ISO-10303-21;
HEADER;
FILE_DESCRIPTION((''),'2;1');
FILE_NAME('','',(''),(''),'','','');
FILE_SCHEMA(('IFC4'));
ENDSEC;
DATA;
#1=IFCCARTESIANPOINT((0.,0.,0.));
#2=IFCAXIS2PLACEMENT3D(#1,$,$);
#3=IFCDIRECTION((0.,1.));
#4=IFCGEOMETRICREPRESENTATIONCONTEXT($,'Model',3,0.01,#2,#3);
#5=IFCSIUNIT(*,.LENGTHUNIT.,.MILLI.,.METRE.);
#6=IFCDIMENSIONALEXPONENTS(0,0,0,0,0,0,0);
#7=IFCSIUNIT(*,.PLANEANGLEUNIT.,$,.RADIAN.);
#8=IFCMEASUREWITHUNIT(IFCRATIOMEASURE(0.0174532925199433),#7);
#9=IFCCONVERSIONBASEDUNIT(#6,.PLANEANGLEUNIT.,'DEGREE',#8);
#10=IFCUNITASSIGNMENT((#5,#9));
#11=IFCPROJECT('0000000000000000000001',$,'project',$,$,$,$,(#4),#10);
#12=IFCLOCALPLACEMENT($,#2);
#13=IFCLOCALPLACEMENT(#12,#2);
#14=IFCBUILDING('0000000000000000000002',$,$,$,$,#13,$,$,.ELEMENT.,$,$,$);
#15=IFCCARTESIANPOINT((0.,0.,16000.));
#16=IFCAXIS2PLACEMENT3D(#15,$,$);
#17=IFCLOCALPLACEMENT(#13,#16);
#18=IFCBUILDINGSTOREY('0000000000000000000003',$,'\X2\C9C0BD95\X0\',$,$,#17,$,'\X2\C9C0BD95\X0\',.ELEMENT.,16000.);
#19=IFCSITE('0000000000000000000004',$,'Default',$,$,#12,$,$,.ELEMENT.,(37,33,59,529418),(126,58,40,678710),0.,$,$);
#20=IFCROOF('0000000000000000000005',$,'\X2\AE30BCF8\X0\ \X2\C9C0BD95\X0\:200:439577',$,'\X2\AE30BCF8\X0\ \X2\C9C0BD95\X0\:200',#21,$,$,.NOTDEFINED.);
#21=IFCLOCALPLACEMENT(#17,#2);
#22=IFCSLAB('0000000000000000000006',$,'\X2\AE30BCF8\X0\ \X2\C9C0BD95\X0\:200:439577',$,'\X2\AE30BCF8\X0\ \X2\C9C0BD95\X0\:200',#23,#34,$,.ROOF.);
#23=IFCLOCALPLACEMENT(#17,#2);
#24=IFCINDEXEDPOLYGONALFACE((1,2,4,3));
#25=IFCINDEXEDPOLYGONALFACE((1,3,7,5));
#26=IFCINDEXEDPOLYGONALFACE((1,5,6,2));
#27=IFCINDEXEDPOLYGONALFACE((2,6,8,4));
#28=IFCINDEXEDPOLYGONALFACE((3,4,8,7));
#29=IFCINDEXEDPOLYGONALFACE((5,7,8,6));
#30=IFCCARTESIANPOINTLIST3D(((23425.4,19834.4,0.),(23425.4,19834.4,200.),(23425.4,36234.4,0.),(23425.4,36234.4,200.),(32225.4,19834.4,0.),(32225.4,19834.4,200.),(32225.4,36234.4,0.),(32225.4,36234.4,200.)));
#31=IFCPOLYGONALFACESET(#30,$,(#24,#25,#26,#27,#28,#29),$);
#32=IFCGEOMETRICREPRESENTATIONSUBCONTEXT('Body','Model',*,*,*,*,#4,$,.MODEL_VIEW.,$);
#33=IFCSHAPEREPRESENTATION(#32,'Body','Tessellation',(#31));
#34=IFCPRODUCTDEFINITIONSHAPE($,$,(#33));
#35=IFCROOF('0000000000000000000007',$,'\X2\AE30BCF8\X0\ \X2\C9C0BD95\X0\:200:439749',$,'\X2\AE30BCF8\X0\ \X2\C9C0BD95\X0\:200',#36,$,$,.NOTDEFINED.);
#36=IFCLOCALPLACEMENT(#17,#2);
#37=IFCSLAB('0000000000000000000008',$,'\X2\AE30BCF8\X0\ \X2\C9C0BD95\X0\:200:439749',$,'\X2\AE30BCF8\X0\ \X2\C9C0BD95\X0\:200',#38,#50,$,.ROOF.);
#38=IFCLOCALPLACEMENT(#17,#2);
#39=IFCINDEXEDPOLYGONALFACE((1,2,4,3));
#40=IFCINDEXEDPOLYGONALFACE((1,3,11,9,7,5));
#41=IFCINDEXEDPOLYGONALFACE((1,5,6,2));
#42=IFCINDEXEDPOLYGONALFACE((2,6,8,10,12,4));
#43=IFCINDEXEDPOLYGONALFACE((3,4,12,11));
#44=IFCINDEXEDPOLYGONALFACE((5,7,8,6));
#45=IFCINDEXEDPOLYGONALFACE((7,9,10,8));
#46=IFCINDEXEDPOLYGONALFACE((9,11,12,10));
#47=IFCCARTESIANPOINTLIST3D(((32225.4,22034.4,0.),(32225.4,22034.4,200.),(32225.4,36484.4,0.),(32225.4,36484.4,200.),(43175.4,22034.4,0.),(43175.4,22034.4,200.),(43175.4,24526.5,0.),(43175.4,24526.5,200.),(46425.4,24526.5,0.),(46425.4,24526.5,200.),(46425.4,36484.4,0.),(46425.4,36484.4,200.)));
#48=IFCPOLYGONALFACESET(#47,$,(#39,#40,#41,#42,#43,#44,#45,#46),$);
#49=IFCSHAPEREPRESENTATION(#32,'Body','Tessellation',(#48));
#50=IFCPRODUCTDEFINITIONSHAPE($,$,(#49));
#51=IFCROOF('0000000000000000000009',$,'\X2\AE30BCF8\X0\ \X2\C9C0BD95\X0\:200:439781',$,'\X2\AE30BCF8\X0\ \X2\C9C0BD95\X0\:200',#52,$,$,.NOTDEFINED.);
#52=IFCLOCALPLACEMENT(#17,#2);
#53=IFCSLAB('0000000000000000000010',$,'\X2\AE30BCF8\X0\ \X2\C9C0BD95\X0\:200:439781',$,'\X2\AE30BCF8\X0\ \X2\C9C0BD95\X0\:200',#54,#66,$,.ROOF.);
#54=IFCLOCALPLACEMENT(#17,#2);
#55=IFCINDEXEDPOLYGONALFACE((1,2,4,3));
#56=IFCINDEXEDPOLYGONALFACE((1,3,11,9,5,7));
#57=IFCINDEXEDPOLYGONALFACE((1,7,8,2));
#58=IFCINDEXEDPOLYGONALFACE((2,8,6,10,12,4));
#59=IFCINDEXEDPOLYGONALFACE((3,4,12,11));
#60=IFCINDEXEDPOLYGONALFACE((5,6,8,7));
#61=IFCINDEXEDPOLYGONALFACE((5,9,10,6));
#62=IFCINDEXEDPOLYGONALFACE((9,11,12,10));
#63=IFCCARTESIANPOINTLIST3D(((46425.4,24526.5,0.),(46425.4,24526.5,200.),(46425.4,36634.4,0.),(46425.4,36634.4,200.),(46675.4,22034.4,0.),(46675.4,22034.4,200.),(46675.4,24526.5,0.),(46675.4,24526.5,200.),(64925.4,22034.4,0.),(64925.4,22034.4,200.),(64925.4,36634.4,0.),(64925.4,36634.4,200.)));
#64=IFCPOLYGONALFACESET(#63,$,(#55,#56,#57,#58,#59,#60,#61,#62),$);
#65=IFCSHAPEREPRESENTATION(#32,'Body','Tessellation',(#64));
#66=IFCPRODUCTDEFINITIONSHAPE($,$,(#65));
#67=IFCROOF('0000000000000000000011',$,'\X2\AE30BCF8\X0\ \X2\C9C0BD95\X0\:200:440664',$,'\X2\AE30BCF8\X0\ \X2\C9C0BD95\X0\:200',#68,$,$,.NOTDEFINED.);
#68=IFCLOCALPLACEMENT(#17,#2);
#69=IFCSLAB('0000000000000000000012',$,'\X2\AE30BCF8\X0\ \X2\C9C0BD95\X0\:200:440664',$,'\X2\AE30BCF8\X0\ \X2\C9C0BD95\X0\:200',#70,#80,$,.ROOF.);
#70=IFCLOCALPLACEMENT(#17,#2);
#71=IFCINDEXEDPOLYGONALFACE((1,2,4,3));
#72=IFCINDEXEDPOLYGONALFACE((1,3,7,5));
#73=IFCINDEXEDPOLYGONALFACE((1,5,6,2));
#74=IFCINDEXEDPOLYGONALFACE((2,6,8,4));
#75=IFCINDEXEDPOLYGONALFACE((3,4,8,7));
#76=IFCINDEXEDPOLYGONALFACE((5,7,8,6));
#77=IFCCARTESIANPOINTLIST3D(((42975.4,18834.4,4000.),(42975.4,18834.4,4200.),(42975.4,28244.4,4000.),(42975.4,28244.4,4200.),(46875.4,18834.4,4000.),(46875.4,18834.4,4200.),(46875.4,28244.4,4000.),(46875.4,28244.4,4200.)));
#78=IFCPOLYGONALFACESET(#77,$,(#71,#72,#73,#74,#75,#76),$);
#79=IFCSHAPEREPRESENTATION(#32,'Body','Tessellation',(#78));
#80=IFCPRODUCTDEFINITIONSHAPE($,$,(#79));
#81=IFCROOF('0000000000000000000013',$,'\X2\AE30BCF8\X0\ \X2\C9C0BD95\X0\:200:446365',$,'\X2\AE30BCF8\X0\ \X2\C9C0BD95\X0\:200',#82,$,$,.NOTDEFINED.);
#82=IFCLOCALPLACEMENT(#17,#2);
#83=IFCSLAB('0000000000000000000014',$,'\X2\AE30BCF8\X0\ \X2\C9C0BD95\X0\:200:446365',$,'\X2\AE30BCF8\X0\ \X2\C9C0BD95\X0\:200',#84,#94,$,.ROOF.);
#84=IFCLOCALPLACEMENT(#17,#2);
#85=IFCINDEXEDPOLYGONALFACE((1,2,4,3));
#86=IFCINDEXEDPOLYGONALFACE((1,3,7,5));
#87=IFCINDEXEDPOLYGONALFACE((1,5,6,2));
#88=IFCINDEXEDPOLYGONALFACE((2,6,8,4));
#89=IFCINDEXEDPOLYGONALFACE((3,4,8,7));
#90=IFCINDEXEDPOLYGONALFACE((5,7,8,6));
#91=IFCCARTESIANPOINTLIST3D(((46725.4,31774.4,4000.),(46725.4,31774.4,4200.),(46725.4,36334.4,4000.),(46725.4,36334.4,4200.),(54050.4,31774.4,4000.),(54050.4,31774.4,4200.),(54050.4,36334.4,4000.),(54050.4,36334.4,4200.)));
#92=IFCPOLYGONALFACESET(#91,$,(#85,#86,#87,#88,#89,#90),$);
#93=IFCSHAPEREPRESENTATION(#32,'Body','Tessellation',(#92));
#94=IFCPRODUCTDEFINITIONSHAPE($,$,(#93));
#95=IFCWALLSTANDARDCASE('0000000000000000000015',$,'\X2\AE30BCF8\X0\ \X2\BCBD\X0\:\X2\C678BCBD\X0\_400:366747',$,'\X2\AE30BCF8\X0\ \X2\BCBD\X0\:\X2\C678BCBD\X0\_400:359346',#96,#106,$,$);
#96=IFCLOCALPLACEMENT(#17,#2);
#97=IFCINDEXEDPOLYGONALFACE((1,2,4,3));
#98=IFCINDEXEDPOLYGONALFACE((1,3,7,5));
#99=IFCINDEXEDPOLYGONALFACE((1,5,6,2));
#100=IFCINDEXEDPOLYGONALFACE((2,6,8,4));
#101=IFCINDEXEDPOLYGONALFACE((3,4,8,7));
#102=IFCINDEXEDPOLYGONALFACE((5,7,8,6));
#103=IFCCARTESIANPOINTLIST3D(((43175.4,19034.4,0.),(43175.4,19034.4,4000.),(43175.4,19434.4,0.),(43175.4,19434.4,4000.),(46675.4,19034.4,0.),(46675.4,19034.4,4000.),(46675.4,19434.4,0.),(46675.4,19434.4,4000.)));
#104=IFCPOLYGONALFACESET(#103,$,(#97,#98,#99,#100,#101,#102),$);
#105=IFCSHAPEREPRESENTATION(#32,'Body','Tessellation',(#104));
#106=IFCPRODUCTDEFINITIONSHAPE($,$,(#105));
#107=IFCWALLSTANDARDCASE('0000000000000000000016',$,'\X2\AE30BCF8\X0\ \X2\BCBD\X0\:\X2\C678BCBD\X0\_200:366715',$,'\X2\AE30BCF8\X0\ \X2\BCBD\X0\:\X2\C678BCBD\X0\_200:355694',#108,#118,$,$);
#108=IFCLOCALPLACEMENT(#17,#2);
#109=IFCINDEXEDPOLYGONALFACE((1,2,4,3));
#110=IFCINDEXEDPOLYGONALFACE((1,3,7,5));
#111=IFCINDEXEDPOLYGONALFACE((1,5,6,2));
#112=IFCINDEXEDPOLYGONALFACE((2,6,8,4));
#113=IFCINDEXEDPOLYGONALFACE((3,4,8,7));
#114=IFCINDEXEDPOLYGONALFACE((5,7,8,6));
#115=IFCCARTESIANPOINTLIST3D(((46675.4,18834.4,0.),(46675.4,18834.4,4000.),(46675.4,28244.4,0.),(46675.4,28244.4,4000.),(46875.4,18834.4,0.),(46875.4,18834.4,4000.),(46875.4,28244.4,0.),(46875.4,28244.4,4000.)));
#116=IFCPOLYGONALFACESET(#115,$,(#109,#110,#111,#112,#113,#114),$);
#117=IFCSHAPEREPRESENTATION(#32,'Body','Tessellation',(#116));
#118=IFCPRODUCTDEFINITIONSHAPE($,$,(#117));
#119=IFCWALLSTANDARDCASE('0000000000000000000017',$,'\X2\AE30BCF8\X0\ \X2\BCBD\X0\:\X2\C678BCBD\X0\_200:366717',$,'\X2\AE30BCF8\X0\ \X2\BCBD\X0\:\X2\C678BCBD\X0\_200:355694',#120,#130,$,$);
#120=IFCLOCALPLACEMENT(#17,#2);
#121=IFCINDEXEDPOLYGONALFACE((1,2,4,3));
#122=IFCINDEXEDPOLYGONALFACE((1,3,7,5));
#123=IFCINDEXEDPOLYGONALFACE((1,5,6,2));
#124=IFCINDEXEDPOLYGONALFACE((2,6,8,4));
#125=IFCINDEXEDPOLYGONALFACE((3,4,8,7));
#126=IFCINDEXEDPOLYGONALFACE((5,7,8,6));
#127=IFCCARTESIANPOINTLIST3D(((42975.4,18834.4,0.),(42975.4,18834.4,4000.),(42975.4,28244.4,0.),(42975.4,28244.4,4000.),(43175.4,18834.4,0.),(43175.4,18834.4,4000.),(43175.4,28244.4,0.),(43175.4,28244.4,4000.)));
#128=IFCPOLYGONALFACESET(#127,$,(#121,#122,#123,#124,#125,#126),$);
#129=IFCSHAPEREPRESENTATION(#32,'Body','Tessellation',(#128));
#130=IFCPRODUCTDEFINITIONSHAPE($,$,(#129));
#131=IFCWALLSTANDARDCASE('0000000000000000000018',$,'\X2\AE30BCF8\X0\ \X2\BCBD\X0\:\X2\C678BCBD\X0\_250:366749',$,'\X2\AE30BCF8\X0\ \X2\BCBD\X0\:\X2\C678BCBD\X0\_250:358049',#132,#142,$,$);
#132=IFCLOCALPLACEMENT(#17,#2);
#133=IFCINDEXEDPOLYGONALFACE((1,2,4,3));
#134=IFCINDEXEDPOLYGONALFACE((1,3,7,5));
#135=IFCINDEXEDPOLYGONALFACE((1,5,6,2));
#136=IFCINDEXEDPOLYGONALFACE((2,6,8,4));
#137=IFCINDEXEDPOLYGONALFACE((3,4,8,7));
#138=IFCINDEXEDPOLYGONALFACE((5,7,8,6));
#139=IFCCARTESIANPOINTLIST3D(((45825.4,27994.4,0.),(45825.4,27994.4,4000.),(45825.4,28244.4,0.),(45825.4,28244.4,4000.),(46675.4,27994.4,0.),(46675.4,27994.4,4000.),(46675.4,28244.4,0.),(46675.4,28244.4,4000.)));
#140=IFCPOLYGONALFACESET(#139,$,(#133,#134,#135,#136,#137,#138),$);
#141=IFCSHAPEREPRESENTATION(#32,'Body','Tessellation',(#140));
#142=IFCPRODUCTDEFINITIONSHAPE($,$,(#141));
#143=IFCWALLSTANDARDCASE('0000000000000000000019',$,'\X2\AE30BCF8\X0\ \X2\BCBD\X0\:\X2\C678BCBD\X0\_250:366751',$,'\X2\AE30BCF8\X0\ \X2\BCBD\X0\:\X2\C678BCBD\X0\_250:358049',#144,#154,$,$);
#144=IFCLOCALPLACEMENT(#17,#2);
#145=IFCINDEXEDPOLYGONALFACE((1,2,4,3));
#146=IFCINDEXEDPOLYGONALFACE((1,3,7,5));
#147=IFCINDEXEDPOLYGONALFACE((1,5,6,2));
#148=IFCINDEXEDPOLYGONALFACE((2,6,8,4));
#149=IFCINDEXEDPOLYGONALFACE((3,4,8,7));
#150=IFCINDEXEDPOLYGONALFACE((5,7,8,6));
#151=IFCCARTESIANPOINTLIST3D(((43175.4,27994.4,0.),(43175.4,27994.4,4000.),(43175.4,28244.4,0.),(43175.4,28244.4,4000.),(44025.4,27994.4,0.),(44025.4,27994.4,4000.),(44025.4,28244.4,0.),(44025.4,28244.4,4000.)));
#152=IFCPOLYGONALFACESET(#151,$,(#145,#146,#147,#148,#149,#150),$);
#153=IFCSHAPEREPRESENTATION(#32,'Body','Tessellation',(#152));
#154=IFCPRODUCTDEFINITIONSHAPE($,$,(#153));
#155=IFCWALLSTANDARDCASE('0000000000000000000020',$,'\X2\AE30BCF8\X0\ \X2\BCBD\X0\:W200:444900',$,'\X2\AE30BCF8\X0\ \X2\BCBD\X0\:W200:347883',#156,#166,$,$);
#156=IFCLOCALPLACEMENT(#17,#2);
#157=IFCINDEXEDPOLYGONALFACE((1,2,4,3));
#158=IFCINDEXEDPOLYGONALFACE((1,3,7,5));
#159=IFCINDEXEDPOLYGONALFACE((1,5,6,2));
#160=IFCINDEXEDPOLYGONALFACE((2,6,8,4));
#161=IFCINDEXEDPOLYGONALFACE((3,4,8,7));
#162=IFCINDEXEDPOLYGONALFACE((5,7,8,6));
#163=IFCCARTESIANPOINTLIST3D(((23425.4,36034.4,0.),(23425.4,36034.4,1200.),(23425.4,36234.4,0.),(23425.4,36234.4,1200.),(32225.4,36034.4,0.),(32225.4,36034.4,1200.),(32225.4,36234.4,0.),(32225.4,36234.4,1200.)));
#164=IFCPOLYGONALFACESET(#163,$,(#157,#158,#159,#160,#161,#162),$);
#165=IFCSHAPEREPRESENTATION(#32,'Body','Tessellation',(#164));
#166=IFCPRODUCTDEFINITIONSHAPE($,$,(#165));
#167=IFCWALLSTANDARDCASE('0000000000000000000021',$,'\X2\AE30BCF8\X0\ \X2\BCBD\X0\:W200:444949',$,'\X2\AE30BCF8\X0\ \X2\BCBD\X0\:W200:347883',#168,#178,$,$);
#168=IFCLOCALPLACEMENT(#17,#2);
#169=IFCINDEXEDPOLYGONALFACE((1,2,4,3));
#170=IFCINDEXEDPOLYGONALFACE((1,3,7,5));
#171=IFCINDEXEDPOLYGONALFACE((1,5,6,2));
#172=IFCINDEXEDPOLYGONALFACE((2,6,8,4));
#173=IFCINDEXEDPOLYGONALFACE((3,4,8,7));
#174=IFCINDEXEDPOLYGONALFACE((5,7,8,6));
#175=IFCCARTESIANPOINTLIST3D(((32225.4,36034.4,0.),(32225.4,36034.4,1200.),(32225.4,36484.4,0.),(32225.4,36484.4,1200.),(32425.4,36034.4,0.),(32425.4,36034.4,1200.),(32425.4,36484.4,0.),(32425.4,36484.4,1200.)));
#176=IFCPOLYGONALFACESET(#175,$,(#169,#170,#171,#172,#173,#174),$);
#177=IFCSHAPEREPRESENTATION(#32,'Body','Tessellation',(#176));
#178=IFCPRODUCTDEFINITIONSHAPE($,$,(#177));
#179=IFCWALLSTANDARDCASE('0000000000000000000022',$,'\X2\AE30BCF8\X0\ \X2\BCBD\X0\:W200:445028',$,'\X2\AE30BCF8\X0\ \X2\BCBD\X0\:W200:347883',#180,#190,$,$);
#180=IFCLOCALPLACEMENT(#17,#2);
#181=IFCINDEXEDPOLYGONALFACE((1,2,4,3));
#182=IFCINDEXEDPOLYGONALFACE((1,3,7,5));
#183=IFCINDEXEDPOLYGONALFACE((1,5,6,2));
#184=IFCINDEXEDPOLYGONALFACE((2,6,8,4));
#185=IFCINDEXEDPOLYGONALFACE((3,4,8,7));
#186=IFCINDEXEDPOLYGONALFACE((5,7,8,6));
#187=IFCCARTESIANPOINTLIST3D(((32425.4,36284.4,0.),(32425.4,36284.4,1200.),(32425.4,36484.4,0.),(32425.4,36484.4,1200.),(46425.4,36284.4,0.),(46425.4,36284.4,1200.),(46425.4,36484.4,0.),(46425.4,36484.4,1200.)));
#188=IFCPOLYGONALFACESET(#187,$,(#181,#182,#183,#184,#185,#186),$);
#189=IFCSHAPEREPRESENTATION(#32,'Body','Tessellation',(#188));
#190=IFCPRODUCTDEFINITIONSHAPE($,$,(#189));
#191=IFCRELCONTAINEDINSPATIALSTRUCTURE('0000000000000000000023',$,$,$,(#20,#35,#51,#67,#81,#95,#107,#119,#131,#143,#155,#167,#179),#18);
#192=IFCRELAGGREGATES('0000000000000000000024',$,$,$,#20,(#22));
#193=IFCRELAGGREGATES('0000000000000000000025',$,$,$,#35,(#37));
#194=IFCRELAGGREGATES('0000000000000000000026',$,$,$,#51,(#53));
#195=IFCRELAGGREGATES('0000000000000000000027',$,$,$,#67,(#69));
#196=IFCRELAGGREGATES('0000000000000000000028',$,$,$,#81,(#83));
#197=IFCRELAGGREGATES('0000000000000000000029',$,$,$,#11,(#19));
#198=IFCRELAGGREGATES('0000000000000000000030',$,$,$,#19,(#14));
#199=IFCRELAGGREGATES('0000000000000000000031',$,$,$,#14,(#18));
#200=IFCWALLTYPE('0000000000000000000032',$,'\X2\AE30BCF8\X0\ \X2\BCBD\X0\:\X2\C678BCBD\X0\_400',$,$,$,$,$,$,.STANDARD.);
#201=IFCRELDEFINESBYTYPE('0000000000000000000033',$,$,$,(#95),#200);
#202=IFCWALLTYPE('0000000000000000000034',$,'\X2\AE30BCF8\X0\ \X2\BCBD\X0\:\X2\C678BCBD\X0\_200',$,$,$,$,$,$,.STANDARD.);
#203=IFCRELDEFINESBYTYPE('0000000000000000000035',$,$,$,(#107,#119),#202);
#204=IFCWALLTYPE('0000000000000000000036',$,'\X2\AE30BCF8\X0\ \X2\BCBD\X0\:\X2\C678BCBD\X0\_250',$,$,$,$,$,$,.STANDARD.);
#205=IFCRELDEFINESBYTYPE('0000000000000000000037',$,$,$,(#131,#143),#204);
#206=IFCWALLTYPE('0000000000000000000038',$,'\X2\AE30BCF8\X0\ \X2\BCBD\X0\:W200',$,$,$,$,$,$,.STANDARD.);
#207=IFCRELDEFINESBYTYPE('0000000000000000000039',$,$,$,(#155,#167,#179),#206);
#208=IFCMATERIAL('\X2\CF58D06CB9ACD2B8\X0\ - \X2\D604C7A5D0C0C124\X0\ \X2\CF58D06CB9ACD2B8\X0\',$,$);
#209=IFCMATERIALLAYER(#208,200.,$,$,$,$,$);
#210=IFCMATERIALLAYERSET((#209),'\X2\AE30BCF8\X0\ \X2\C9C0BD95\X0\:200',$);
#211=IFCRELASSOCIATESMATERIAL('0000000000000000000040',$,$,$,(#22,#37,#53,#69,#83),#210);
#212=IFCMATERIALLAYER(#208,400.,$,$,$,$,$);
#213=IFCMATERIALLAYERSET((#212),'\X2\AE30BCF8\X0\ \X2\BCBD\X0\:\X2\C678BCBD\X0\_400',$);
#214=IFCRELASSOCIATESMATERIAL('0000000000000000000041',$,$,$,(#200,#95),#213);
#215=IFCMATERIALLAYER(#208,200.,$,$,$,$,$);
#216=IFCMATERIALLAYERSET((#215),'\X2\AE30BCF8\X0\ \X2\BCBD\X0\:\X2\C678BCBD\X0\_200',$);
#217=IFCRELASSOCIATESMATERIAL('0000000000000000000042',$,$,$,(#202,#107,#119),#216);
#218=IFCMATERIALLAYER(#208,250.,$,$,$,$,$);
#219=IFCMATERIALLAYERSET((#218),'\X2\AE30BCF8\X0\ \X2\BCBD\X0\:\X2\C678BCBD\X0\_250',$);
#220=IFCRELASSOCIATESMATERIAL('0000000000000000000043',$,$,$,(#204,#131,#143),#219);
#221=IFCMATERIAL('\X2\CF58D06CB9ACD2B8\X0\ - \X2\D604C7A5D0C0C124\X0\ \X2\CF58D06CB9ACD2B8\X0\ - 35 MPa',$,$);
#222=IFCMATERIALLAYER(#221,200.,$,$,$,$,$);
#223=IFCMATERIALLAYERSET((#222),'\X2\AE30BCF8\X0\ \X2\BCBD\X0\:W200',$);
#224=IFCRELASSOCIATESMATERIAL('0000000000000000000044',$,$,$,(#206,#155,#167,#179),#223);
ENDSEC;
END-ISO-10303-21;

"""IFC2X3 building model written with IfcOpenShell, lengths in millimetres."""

from ifc_helpers import new_model, entity, si_unit, converted_unit, direction, frame, frame_2d, origin, place, context, subcontext, project, spatial, polyline, rectangle, outline, extrude, material, layer, layer_set, layer_usage, type_object, element, aggregate, save


model = new_model("IFC2X3")

# Units and contexts
model_context = context("Model", 3, precision=0.01, world=origin(), true_north=direction((0.0, 1.0)))
body_context = subcontext(model_context, "Body", "Model", "MODEL_VIEW")
ifc_project = project(units=[si_unit("LENGTHUNIT", "METRE", prefix="MILLI"), converted_unit("PLANEANGLEUNIT", "DEGREE", entity("IfcRatioMeasure", 0.0174532925199433), si_unit("PLANEANGLEUNIT", "RADIAN"), dimensions=[0, 0, 0, 0, 0, 0, 0])], contexts=[model_context])

# Site, building, storey
site_placement = place(None, origin())
site = spatial("IfcSite", under=ifc_project, at=site_placement, Name="Default", CompositionType="ELEMENT", RefLatitude=(37, 33, 59, 529418), RefLongitude=(126, 58, 40, 678710), RefElevation=0.0)
building_placement = place(site_placement, origin())
building = spatial("IfcBuilding", under=site, at=building_placement, CompositionType="ELEMENT")
storey_placement = place(building_placement, frame((0.0, 0.0, 16000.0)))
storey = spatial("IfcBuildingStorey", under=building, at=storey_placement, Name="지붕", LongName="지붕", CompositionType="ELEMENT", Elevation=16000.0)

# Roofs, slabs
roof_1_placement = place(storey_placement, frame((23425.4, 19834.4, 0.0)))
roof_1 = element("IfcRoof", 1, at=roof_1_placement, inside=storey, Name="기본 지붕:200:439577", ObjectType="기본 지붕:200", ShapeType="NOTDEFINED")
ifc_material_1 = material(Name="콘크리트 - 현장타설 콘크리트")
ifc_layer_1 = layer(ifc_material_1, 200.0)
ifc_layer_set_1 = layer_set([ifc_layer_1], Name="기본 지붕:200")
slab_1_placement = place(roof_1_placement, origin())
slab_1 = element("IfcSlab", 2, at=slab_1_placement, material=ifc_layer_set_1, Name="기본 지붕:200:439577", ObjectType="기본 지붕:200", PredefinedType="ROOF", context=body_context, shape_type="SweptSolid", body=[
    extrude(rectangle(XDim=8800.0, YDim=16400.0, at=frame_2d((0.0, 0.0), x_axis=(1.0, 0.0))), frame((4400.0, 8200.0, 0.0)), (0.0, 0.0, 1.0), 200.0),
])
aggregate(roof_1, [slab_1])
roof_2_placement = place(storey_placement, frame((32225.4, 22034.4, 0.0)))
roof_2 = element("IfcRoof", 3, at=roof_2_placement, inside=storey, Name="기본 지붕:200:439749", ObjectType="기본 지붕:200", ShapeType="NOTDEFINED")
slab_2_placement = place(roof_2_placement, origin())
slab_2 = element("IfcSlab", 4, at=slab_2_placement, material=ifc_layer_set_1, Name="기본 지붕:200:439749", ObjectType="기본 지붕:200", PredefinedType="ROOF", context=body_context, shape_type="SweptSolid", body=[
    extrude(outline(polyline([(-7100.0, 7225.0), (-7100.0, -7225.0), (3850.0, -7225.0), (3850.0, -4733.0), (7100.0, -4733.0), (7100.0, 7225.0), (-7100.0, 7225.0)])), frame((7100.0, 7225.0, 0.0)), (0.0, 0.0, 1.0), 200.0),
])
aggregate(roof_2, [slab_2])
roof_3_placement = place(storey_placement, frame((46425.4, 22034.4, 0.0)))
roof_3 = element("IfcRoof", 5, at=roof_3_placement, inside=storey, Name="기본 지붕:200:439781", ObjectType="기본 지붕:200", ShapeType="NOTDEFINED")
slab_3_placement = place(roof_3_placement, origin())
slab_3 = element("IfcSlab", 6, at=slab_3_placement, material=ifc_layer_set_1, Name="기본 지붕:200:439781", ObjectType="기본 지붕:200", PredefinedType="ROOF", context=body_context, shape_type="SweptSolid", body=[
    extrude(outline(polyline([(-9250.0, 7300.0), (-9250.0, -4808.0), (-9000.0, -4808.0), (-9000.0, -7300.0), (9250.0, -7300.0), (9250.0, 7300.0), (-9250.0, 7300.0)])), frame((9250.0, 7300.0, 0.0)), (0.0, 0.0, 1.0), 200.0),
])
aggregate(roof_3, [slab_3])
roof_4_placement = place(storey_placement, frame((42975.4, 18834.4, 4000.0)))
roof_4 = element("IfcRoof", 7, at=roof_4_placement, inside=storey, Name="기본 지붕:200:440664", ObjectType="기본 지붕:200", ShapeType="NOTDEFINED")
slab_4_placement = place(roof_4_placement, origin())
slab_4 = element("IfcSlab", 8, at=slab_4_placement, material=ifc_layer_set_1, Name="기본 지붕:200:440664", ObjectType="기본 지붕:200", PredefinedType="ROOF", context=body_context, shape_type="SweptSolid", body=[
    extrude(rectangle(XDim=3900.0, YDim=9410.0, at=frame_2d((0.0, 0.0), x_axis=(1.0, 0.0))), frame((1950.0, 4705.0, 0.0)), (0.0, 0.0, 1.0), 200.0),
])
aggregate(roof_4, [slab_4])
roof_5_placement = place(storey_placement, frame((46725.4, 31774.4, 4000.0)))
roof_5 = element("IfcRoof", 9, at=roof_5_placement, inside=storey, Name="기본 지붕:200:446365", ObjectType="기본 지붕:200", ShapeType="NOTDEFINED")
slab_5_placement = place(roof_5_placement, origin())
slab_5 = element("IfcSlab", 10, at=slab_5_placement, material=ifc_layer_set_1, Name="기본 지붕:200:446365", ObjectType="기본 지붕:200", PredefinedType="ROOF", context=body_context, shape_type="SweptSolid", body=[
    extrude(rectangle(XDim=7325.0, YDim=4560.0, at=frame_2d((0.0, 0.0), x_axis=(1.0, 0.0))), frame((3662.5, 2280.0, 0.0)), (0.0, 0.0, 1.0), 200.0),
])
aggregate(roof_5, [slab_5])

# Walls
ifc_layer_2 = layer(ifc_material_1, 400.0)
ifc_layer_set_2 = layer_set([ifc_layer_2], Name="기본 벽:외벽_400")
ifc_layer_usage_1 = layer_usage(ifc_layer_set_2, "AXIS2", "NEGATIVE", 200.0)
wall_type_1 = type_object("IfcWallType", Name="기본 벽:외벽_400", PredefinedType="STANDARD", material=ifc_layer_set_2)
wall_1_placement = place(storey_placement, frame((46675.4, 19234.4, 0.0), z_axis=(0.0, 0.0, 1.0), x_axis=(-1.0, 0.0, 0.0)))
element("IfcWallStandardCase", 11, at=wall_1_placement, inside=storey, type_object=wall_type_1, material=ifc_layer_usage_1, Name="기본 벽:외벽_400:366747", ObjectType="기본 벽:외벽_400:359346", context=body_context, shape_type="SweptSolid", body=[
    extrude(rectangle(XDim=3500.0, YDim=400.0, at=frame_2d((1750.0, 0.0), x_axis=(-1.0, 0.0))), origin(), (0.0, 0.0, 1.0), 4000.0),
])
ifc_layer_3 = layer(ifc_material_1, 200.0)
ifc_layer_set_3 = layer_set([ifc_layer_3], Name="기본 벽:외벽_200")
ifc_layer_usage_2 = layer_usage(ifc_layer_set_3, "AXIS2", "NEGATIVE", 100.0)
wall_type_2 = type_object("IfcWallType", Name="기본 벽:외벽_200", PredefinedType="STANDARD", material=ifc_layer_set_3)
wall_2_placement = place(storey_placement, frame((46775.4, 18834.4, 0.0), z_axis=(0.0, 0.0, 1.0), x_axis=(0.0, 1.0, 0.0)))
element("IfcWallStandardCase", 12, at=wall_2_placement, inside=storey, type_object=wall_type_2, material=ifc_layer_usage_2, Name="기본 벽:외벽_200:366715", ObjectType="기본 벽:외벽_200:355694", context=body_context, shape_type="SweptSolid", body=[
    extrude(rectangle(XDim=9410.0, YDim=200.0, at=frame_2d((4705.0, 0.0), x_axis=(-1.0, 0.0))), origin(), (0.0, 0.0, 1.0), 4000.0),
])
ifc_layer_usage_3 = layer_usage(ifc_layer_set_3, "AXIS2", "NEGATIVE", 100.0)
wall_3_placement = place(storey_placement, frame((43075.4, 18834.4, 0.0), z_axis=(0.0, 0.0, 1.0), x_axis=(0.0, 1.0, 0.0)))
element("IfcWallStandardCase", 13, at=wall_3_placement, inside=storey, type_object=wall_type_2, material=ifc_layer_usage_3, Name="기본 벽:외벽_200:366717", ObjectType="기본 벽:외벽_200:355694", context=body_context, shape_type="SweptSolid", body=[
    extrude(rectangle(XDim=9410.0, YDim=200.0, at=frame_2d((4705.0, 0.0), x_axis=(-1.0, 0.0))), origin(), (0.0, 0.0, 1.0), 4000.0),
])
ifc_layer_4 = layer(ifc_material_1, 250.0)
ifc_layer_set_4 = layer_set([ifc_layer_4], Name="기본 벽:외벽_250")
ifc_layer_usage_4 = layer_usage(ifc_layer_set_4, "AXIS2", "NEGATIVE", 125.0)
wall_type_3 = type_object("IfcWallType", Name="기본 벽:외벽_250", PredefinedType="STANDARD", material=ifc_layer_set_4)
wall_4_placement = place(storey_placement, frame((46675.4, 28119.4, 0.0), z_axis=(0.0, 0.0, 1.0), x_axis=(-1.0, 0.0, 0.0)))
element("IfcWallStandardCase", 14, at=wall_4_placement, inside=storey, type_object=wall_type_3, material=ifc_layer_usage_4, Name="기본 벽:외벽_250:366749", ObjectType="기본 벽:외벽_250:358049", context=body_context, shape_type="SweptSolid", body=[
    extrude(rectangle(XDim=850.0, YDim=250.0, at=frame_2d((425.0, 0.0), x_axis=(-1.0, 0.0))), origin(), (0.0, 0.0, 1.0), 4000.0),
])
ifc_layer_usage_5 = layer_usage(ifc_layer_set_4, "AXIS2", "NEGATIVE", 125.0)
wall_5_placement = place(storey_placement, frame((44025.4, 28119.4, 0.0), z_axis=(0.0, 0.0, 1.0), x_axis=(-1.0, 0.0, 0.0)))
element("IfcWallStandardCase", 15, at=wall_5_placement, inside=storey, type_object=wall_type_3, material=ifc_layer_usage_5, Name="기본 벽:외벽_250:366751", ObjectType="기본 벽:외벽_250:358049", context=body_context, shape_type="SweptSolid", body=[
    extrude(rectangle(XDim=850.0, YDim=250.0, at=frame_2d((425.0, 0.0), x_axis=(-1.0, 0.0))), origin(), (0.0, 0.0, 1.0), 4000.0),
])
ifc_material_2 = material(Name="콘크리트 - 현장타설 콘크리트 - 35 MPa")
ifc_layer_5 = layer(ifc_material_2, 200.0)
ifc_layer_set_5 = layer_set([ifc_layer_5], Name="기본 벽:W200")
ifc_layer_usage_6 = layer_usage(ifc_layer_set_5, "AXIS2", "NEGATIVE", 100.0)
wall_type_4 = type_object("IfcWallType", Name="기본 벽:W200", PredefinedType="STANDARD", material=ifc_layer_set_5)
wall_6_placement = place(storey_placement, frame((23425.4, 36134.4, 0.0)))
element("IfcWallStandardCase", 16, at=wall_6_placement, inside=storey, type_object=wall_type_4, material=ifc_layer_usage_6, Name="기본 벽:W200:444900", ObjectType="기본 벽:W200:347883", context=body_context, shape_type="SweptSolid", body=[
    extrude(rectangle(XDim=8800.0, YDim=200.0, at=frame_2d((4400.0, 0.0), x_axis=(-1.0, 0.0))), origin(), (0.0, 0.0, 1.0), 1200.0),
])
ifc_layer_usage_7 = layer_usage(ifc_layer_set_5, "AXIS2", "NEGATIVE", 100.0)
wall_7_placement = place(storey_placement, frame((32325.4, 36034.4, 0.0), z_axis=(0.0, 0.0, 1.0), x_axis=(0.0, 1.0, 0.0)))
element("IfcWallStandardCase", 17, at=wall_7_placement, inside=storey, type_object=wall_type_4, material=ifc_layer_usage_7, Name="기본 벽:W200:444949", ObjectType="기본 벽:W200:347883", context=body_context, shape_type="SweptSolid", body=[
    extrude(rectangle(XDim=450.0, YDim=200.0, at=frame_2d((225.0, 0.0), x_axis=(-1.0, 0.0))), origin(), (0.0, 0.0, 1.0), 1200.0),
])
ifc_layer_usage_8 = layer_usage(ifc_layer_set_5, "AXIS2", "NEGATIVE", 100.0)
wall_8_placement = place(storey_placement, frame((32425.4, 36384.4, 0.0)))
element("IfcWallStandardCase", 18, at=wall_8_placement, inside=storey, type_object=wall_type_4, material=ifc_layer_usage_8, Name="기본 벽:W200:445028", ObjectType="기본 벽:W200:347883", context=body_context, shape_type="SweptSolid", body=[
    extrude(rectangle(XDim=14000.0, YDim=200.0, at=frame_2d((7000.0, 0.0), x_axis=(-1.0, 0.0))), origin(), (0.0, 0.0, 1.0), 1200.0),
])

save(model, "model.ifc")
